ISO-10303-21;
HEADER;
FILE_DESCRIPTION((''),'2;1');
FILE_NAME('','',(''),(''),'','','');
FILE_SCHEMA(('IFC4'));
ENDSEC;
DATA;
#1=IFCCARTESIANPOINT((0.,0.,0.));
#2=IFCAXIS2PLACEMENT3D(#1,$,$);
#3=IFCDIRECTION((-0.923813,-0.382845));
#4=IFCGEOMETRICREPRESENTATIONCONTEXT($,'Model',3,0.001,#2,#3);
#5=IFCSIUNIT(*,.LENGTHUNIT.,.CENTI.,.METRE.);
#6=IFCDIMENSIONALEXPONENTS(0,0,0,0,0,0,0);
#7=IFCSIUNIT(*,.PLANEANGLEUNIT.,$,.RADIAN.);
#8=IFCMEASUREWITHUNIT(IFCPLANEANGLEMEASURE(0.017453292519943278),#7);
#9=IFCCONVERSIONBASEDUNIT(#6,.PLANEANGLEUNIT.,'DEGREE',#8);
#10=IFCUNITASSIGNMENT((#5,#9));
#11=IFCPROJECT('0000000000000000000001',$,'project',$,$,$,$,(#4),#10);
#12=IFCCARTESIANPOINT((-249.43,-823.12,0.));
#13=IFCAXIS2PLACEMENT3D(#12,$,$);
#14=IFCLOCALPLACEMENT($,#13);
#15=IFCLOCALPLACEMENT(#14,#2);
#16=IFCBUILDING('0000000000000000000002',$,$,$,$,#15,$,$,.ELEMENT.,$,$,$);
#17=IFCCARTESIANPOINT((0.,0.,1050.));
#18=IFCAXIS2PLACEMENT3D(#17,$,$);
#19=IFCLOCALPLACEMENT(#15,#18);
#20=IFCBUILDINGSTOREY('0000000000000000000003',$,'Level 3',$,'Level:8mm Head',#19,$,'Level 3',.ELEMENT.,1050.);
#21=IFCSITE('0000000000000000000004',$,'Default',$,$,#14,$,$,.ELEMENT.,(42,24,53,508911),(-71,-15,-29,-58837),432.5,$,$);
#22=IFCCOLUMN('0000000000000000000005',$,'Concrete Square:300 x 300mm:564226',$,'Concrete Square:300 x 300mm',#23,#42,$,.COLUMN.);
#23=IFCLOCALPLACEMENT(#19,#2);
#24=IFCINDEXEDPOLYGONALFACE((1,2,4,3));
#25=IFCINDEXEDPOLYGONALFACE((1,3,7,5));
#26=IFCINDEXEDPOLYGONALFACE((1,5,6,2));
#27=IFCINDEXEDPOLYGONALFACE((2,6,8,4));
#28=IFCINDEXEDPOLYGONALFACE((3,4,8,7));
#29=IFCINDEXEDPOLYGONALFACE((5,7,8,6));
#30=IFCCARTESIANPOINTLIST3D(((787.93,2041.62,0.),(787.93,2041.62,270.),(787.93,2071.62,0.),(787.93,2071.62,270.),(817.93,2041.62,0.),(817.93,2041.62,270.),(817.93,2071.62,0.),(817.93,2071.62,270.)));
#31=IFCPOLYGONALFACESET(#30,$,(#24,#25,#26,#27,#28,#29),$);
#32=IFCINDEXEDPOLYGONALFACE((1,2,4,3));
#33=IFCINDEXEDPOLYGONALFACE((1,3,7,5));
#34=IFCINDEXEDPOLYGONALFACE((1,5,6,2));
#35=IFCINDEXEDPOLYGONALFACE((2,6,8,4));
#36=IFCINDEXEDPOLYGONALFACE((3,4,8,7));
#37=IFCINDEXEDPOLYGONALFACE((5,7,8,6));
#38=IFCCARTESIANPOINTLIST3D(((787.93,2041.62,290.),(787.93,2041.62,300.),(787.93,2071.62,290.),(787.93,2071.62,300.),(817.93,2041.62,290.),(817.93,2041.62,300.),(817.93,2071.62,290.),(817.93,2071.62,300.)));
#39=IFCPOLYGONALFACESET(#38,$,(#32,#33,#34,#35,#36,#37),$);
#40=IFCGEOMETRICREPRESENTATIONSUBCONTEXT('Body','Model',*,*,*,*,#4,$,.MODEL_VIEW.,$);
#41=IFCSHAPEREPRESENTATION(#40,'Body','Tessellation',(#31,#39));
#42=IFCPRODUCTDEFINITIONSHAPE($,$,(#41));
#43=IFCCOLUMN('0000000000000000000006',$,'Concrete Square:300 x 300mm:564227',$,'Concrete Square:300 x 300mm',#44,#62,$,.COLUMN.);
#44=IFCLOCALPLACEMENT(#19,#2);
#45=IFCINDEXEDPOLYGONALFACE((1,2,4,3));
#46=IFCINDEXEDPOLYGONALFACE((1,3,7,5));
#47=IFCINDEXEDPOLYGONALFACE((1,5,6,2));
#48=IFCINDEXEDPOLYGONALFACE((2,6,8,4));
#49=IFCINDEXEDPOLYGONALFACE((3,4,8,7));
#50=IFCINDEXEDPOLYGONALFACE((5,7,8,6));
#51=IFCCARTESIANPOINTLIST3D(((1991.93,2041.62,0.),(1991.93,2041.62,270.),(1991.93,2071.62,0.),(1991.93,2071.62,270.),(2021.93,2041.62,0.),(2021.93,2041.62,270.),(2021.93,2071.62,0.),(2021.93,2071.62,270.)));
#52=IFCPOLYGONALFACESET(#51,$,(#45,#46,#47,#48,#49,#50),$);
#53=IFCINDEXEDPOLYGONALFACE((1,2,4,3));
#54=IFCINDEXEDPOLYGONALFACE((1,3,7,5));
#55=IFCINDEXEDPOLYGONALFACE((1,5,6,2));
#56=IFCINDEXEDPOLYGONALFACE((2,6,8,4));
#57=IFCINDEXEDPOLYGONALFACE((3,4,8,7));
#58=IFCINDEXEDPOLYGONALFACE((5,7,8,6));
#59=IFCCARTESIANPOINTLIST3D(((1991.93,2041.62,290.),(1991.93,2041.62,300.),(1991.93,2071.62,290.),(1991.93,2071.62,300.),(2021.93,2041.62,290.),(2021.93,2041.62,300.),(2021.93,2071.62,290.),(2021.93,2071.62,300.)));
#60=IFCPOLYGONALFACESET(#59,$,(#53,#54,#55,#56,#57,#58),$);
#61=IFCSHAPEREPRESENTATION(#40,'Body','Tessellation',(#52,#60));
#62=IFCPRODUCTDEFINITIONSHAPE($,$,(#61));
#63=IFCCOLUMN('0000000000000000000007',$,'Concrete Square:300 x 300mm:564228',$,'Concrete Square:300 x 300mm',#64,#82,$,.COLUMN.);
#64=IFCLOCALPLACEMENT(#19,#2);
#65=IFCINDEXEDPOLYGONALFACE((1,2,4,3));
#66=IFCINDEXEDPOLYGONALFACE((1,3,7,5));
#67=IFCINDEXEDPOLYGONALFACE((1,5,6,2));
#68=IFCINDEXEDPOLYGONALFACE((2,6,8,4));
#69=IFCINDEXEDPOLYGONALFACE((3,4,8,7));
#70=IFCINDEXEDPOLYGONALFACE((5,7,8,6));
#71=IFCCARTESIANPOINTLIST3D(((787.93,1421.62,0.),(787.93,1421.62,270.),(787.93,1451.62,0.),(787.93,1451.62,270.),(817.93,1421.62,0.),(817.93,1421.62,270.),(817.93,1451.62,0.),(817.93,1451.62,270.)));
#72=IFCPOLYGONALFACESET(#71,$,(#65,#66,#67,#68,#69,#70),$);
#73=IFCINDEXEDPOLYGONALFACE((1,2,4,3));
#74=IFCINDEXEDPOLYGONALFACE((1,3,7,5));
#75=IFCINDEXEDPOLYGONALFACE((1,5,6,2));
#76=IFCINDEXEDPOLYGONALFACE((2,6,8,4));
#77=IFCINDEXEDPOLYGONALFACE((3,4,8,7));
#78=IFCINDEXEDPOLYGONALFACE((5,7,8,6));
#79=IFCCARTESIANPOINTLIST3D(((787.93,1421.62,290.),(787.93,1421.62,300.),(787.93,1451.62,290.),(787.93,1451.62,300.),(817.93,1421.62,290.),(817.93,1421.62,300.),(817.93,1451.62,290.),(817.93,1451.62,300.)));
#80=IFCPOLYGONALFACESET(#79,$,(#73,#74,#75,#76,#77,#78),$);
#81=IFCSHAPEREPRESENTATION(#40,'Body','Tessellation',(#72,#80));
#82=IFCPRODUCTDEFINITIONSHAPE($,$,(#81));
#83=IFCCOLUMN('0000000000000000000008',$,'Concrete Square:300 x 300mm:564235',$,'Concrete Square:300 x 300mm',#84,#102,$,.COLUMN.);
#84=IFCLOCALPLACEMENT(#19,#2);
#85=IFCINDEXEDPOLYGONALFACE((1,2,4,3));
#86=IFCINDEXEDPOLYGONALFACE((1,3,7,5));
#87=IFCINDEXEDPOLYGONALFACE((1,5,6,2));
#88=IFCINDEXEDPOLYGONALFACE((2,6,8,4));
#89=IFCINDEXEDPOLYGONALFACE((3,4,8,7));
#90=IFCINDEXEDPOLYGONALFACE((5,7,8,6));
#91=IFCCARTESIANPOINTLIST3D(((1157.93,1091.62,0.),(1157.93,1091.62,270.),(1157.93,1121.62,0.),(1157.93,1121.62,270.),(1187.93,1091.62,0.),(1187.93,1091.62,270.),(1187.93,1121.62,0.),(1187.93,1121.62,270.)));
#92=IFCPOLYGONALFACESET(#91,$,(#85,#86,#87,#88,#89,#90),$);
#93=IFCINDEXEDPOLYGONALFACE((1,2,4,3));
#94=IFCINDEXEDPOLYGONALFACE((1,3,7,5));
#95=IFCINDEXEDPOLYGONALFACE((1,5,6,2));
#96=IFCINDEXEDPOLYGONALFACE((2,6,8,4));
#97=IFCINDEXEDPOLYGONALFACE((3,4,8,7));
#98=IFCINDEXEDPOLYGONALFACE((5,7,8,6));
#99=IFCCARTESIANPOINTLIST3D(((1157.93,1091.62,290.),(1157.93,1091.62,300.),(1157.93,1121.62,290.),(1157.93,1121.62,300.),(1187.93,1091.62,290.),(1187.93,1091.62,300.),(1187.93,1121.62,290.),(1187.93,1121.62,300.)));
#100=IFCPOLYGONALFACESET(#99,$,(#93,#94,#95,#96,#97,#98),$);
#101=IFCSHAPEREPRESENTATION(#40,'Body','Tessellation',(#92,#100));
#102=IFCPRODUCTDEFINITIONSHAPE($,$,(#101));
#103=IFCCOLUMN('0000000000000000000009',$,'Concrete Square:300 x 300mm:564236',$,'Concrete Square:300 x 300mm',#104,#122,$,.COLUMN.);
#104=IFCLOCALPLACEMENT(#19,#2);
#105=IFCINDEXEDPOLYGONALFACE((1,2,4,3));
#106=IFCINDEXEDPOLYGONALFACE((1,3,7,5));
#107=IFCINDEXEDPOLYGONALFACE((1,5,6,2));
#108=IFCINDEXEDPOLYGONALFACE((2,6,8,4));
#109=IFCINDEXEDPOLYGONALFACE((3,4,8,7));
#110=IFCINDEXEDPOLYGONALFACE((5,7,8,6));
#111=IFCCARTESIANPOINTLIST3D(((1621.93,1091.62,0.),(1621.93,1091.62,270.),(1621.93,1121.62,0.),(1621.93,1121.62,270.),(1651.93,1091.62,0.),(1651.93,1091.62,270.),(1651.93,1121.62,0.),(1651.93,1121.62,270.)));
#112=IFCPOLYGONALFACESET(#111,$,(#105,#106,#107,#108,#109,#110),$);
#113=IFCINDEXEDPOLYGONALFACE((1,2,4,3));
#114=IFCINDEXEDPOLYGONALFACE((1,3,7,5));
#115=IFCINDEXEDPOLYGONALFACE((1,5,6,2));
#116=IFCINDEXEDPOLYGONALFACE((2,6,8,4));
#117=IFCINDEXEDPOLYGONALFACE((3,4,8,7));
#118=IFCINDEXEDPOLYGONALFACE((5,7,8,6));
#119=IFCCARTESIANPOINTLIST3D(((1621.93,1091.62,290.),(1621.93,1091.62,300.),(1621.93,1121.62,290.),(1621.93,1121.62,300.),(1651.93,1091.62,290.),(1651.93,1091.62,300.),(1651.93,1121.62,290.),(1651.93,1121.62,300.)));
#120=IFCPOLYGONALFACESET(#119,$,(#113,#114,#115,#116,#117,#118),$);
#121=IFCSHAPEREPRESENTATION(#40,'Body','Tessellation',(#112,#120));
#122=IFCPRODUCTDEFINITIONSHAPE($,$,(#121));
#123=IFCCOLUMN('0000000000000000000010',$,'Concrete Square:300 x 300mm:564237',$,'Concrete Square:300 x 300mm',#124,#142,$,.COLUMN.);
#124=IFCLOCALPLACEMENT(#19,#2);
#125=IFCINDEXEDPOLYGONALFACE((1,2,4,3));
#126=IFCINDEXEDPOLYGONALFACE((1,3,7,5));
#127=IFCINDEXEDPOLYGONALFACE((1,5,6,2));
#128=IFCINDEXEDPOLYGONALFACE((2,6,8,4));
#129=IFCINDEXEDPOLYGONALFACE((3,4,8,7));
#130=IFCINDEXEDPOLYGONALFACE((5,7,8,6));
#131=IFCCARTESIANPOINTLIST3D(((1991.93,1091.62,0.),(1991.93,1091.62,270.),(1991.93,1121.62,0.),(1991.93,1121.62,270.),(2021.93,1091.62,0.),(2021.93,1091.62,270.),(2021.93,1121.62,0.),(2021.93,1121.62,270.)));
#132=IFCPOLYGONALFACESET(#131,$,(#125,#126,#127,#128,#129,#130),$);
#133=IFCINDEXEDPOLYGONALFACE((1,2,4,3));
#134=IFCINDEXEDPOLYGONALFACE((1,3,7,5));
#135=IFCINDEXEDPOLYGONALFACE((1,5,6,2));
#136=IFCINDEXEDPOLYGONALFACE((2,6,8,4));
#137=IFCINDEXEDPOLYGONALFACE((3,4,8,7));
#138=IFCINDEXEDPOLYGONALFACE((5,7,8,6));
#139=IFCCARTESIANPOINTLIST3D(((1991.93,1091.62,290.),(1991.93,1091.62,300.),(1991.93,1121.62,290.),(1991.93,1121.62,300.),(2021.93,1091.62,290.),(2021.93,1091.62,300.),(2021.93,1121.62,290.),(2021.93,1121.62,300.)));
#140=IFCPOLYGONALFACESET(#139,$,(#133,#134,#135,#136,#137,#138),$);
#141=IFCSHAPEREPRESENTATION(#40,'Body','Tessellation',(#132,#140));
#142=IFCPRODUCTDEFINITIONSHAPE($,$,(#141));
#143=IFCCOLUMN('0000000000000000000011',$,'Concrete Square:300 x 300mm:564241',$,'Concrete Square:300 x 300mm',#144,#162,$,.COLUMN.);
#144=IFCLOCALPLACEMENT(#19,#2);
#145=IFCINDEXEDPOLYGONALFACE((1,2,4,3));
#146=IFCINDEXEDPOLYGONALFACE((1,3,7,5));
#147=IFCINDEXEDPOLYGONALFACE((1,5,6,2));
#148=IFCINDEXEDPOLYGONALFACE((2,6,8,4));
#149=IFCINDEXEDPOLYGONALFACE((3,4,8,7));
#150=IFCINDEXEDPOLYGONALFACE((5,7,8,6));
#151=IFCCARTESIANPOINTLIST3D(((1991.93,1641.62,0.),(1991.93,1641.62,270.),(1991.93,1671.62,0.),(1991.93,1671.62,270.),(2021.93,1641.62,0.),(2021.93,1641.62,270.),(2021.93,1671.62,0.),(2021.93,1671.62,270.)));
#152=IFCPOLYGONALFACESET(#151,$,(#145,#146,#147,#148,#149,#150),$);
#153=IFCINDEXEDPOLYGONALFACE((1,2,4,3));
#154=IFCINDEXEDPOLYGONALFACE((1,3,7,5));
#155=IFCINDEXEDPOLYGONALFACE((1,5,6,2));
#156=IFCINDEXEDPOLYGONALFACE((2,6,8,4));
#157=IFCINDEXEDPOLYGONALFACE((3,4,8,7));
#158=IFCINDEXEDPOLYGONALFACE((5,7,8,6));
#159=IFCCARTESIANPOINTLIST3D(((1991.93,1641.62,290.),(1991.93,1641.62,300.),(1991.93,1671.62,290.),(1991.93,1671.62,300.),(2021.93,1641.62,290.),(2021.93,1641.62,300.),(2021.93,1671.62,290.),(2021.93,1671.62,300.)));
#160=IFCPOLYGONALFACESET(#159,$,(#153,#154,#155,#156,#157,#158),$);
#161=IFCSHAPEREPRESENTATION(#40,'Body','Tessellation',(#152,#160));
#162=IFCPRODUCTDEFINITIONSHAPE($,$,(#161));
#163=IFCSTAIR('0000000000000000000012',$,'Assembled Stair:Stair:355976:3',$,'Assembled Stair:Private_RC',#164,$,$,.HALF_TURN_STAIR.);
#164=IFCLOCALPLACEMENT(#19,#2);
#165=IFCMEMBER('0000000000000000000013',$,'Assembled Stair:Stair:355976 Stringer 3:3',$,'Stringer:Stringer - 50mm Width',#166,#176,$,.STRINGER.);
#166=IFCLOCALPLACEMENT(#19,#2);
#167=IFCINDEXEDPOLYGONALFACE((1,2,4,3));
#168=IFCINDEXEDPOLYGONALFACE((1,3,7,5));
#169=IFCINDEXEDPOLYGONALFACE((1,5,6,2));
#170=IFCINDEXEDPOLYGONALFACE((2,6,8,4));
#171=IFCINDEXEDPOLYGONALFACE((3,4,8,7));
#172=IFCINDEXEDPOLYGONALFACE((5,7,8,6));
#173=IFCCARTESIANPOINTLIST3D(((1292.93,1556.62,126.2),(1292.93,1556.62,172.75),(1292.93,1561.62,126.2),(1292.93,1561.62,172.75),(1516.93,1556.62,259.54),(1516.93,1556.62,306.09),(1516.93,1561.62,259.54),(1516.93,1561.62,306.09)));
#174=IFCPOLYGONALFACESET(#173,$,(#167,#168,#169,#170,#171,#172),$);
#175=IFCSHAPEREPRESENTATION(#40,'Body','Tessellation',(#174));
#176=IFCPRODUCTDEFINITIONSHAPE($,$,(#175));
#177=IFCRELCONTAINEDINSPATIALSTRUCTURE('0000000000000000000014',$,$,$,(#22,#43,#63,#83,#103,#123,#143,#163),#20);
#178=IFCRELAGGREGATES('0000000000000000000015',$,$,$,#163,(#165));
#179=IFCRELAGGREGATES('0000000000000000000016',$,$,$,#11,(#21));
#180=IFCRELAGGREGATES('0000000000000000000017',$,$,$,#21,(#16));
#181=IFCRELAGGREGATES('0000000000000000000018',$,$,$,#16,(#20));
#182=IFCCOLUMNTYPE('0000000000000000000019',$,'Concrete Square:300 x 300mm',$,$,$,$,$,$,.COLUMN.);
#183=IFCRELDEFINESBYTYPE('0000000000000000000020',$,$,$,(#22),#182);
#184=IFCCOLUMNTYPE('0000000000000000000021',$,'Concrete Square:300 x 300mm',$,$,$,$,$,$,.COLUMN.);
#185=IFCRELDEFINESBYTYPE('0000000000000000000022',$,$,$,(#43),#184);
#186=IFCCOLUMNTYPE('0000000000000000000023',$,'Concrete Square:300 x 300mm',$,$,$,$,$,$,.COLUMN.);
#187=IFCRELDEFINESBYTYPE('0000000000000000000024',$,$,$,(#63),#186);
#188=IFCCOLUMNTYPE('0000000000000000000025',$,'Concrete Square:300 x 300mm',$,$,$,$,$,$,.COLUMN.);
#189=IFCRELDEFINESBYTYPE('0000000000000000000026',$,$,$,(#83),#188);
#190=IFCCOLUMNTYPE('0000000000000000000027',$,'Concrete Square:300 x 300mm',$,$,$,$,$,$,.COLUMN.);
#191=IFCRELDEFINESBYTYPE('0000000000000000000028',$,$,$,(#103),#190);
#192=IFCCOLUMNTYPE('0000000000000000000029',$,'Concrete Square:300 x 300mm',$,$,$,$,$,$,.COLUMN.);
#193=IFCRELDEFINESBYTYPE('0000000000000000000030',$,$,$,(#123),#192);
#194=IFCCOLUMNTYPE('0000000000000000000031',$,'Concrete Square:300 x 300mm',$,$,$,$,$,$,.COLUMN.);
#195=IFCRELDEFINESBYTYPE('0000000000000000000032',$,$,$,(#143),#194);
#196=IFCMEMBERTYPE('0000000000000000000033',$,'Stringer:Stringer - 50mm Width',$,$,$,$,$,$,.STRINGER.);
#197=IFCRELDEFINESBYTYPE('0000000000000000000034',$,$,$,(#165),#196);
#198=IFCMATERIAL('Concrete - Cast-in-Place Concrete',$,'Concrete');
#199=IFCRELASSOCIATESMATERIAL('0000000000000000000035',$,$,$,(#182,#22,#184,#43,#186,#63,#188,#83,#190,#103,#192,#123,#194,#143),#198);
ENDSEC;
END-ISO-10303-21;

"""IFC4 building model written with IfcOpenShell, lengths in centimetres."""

from ifc_helpers import new_model, entity, si_unit, converted_unit, direction, frame, origin, place, context, subcontext, project, spatial, indexed_curve, outline, extrude, source, transform, mapped, material, type_object, type_shapes, element, aggregate, save


model = new_model("IFC4")

# Units and contexts
model_context = context("Model", 3, precision=0.001, world=origin(), true_north=direction((-0.923813, -0.382845)))
body_context = subcontext(model_context, "Body", "Model", "MODEL_VIEW")
ifc_project = project(units=[si_unit("LENGTHUNIT", "METRE", prefix="CENTI"), converted_unit("PLANEANGLEUNIT", "DEGREE", entity("IfcPlaneAngleMeasure", 0.017453292519943278), si_unit("PLANEANGLEUNIT", "RADIAN"), dimensions=[0, 0, 0, 0, 0, 0, 0])], contexts=[model_context])

# Site, building, storey
site_placement = place(None, frame((-249.43, -823.12, 0.0)))
site = spatial("IfcSite", under=ifc_project, at=site_placement, Name="Default", CompositionType="ELEMENT", RefLatitude=(42, 24, 53, 508911), RefLongitude=(-71, -15, -29, -58837), RefElevation=432.5)
building_placement = place(site_placement, origin())
building = spatial("IfcBuilding", under=site, at=building_placement, CompositionType="ELEMENT")
storey_placement = place(building_placement, frame((0.0, 0.0, 1050.0)))
storey = spatial("IfcBuildingStorey", under=building, at=storey_placement, Name="Level 3", ObjectType="Level:8mm Head", LongName="Level 3", CompositionType="ELEMENT", Elevation=1050.0)

# Columns
ifc_material_1 = material(Name="Concrete - Cast-in-Place Concrete", Category="Concrete")
column_type_1 = type_object("IfcColumnType", Name="Concrete Square:300 x 300mm", PredefinedType="COLUMN", material=ifc_material_1)
shared_shape_1 = source(origin(), body_context, "Body", "SweptSolid", [
    extrude(outline(indexed_curve([(-15.0, -15.0), (15.0, -15.0), (15.0, 15.0), (-15.0, 15.0), (-15.0, -15.0)], self_intersect=False)), frame((802.93, 2056.62, 1050.0), z_axis=(0.0, 0.0, 1.0), x_axis=(-1.0, 0.0, 0.0)), (0.0, 0.0, 1.0), 270.0),
    extrude(outline(indexed_curve([(-15.0, -15.0), (15.0, -15.0), (15.0, 15.0), (-15.0, 15.0), (-15.0, -15.0)], self_intersect=False)), frame((802.93, 2056.62, 1340.0), z_axis=(0.0, 0.0, 1.0), x_axis=(-1.0, 0.0, 0.0)), (0.0, 0.0, 1.0), 10.0),
])
type_shapes(column_type_1, [shared_shape_1])
column_1_placement = place(storey_placement, frame((0.0, 0.0, -1050.0)))
element("IfcColumn", 1, at=column_1_placement, inside=storey, type_object=column_type_1, material=ifc_material_1, Name="Concrete Square:300 x 300mm:564226", ObjectType="Concrete Square:300 x 300mm", PredefinedType="COLUMN", context=body_context, shape_type="MappedRepresentation", body=[
    mapped(shared_shape_1, transform((0.0, 0.0, 0.0), scale=1.0)),
])
column_type_2 = type_object("IfcColumnType", Name="Concrete Square:300 x 300mm", PredefinedType="COLUMN", material=ifc_material_1)
shared_shape_2 = source(origin(), body_context, "Body", "SweptSolid", [
    extrude(outline(indexed_curve([(-15.0, -15.0), (15.0, -15.0), (15.0, 15.0), (-15.0, 15.0), (-15.0, -15.0)], self_intersect=False)), frame((2006.93, 2056.62, 1050.0), z_axis=(0.0, 0.0, 1.0), x_axis=(-1.0, 0.0, 0.0)), (0.0, 0.0, 1.0), 270.0),
    extrude(outline(indexed_curve([(-15.0, -15.0), (15.0, -15.0), (15.0, 15.0), (-15.0, 15.0), (-15.0, -15.0)], self_intersect=False)), frame((2006.93, 2056.62, 1340.0), z_axis=(0.0, 0.0, 1.0), x_axis=(-1.0, 0.0, 0.0)), (0.0, 0.0, 1.0), 10.0),
])
type_shapes(column_type_2, [shared_shape_2])
column_2_placement = place(storey_placement, frame((0.0, 0.0, -1050.0)))
element("IfcColumn", 2, at=column_2_placement, inside=storey, type_object=column_type_2, material=ifc_material_1, Name="Concrete Square:300 x 300mm:564227", ObjectType="Concrete Square:300 x 300mm", PredefinedType="COLUMN", context=body_context, shape_type="MappedRepresentation", body=[
    mapped(shared_shape_2, transform((0.0, 0.0, 0.0), scale=1.0)),
])
column_type_3 = type_object("IfcColumnType", Name="Concrete Square:300 x 300mm", PredefinedType="COLUMN", material=ifc_material_1)
shared_shape_3 = source(origin(), body_context, "Body", "SweptSolid", [
    extrude(outline(indexed_curve([(-15.0, -15.0), (15.0, -15.0), (15.0, 15.0), (-15.0, 15.0), (-15.0, -15.0)], self_intersect=False)), frame((802.93, 1436.62, 1050.0), z_axis=(0.0, 0.0, 1.0), x_axis=(-1.0, 0.0, 0.0)), (0.0, 0.0, 1.0), 270.0),
    extrude(outline(indexed_curve([(-15.0, -15.0), (15.0, -15.0), (15.0, 15.0), (-15.0, 15.0), (-15.0, -15.0)], self_intersect=False)), frame((802.93, 1436.62, 1340.0), z_axis=(0.0, 0.0, 1.0), x_axis=(-1.0, 0.0, 0.0)), (0.0, 0.0, 1.0), 10.0),
])
type_shapes(column_type_3, [shared_shape_3])
column_3_placement = place(storey_placement, frame((0.0, 0.0, -1050.0)))
element("IfcColumn", 3, at=column_3_placement, inside=storey, type_object=column_type_3, material=ifc_material_1, Name="Concrete Square:300 x 300mm:564228", ObjectType="Concrete Square:300 x 300mm", PredefinedType="COLUMN", context=body_context, shape_type="MappedRepresentation", body=[
    mapped(shared_shape_3, transform((0.0, 0.0, 0.0), scale=1.0)),
])
column_type_4 = type_object("IfcColumnType", Name="Concrete Square:300 x 300mm", PredefinedType="COLUMN", material=ifc_material_1)
shared_shape_4 = source(origin(), body_context, "Body", "SweptSolid", [
    extrude(outline(indexed_curve([(-15.0, -15.0), (15.0, -15.0), (15.0, 15.0), (-15.0, 15.0), (-15.0, -15.0)], self_intersect=False)), frame((1172.93, 1106.62, 1050.0), z_axis=(0.0, 0.0, 1.0), x_axis=(-1.0, 0.0, 0.0)), (0.0, 0.0, 1.0), 270.0),
    extrude(outline(indexed_curve([(-15.0, -15.0), (15.0, -15.0), (15.0, 15.0), (-15.0, 15.0), (-15.0, -15.0)], self_intersect=False)), frame((1172.93, 1106.62, 1340.0), z_axis=(0.0, 0.0, 1.0), x_axis=(-1.0, 0.0, 0.0)), (0.0, 0.0, 1.0), 10.0),
])
type_shapes(column_type_4, [shared_shape_4])
column_4_placement = place(storey_placement, frame((0.0, 0.0, -1050.0)))
element("IfcColumn", 4, at=column_4_placement, inside=storey, type_object=column_type_4, material=ifc_material_1, Name="Concrete Square:300 x 300mm:564235", ObjectType="Concrete Square:300 x 300mm", PredefinedType="COLUMN", context=body_context, shape_type="MappedRepresentation", body=[
    mapped(shared_shape_4, transform((0.0, 0.0, 0.0), scale=1.0)),
])
column_type_5 = type_object("IfcColumnType", Name="Concrete Square:300 x 300mm", PredefinedType="COLUMN", material=ifc_material_1)
shared_shape_5 = source(origin(), body_context, "Body", "SweptSolid", [
    extrude(outline(indexed_curve([(-15.0, -15.0), (15.0, -15.0), (15.0, 15.0), (-15.0, 15.0), (-15.0, -15.0)], self_intersect=False)), frame((1636.93, 1106.62, 1050.0), z_axis=(0.0, 0.0, 1.0), x_axis=(-1.0, 0.0, 0.0)), (0.0, 0.0, 1.0), 270.0),
    extrude(outline(indexed_curve([(-15.0, -15.0), (15.0, -15.0), (15.0, 15.0), (-15.0, 15.0), (-15.0, -15.0)], self_intersect=False)), frame((1636.93, 1106.62, 1340.0), z_axis=(0.0, 0.0, 1.0), x_axis=(-1.0, 0.0, 0.0)), (0.0, 0.0, 1.0), 10.0),
])
type_shapes(column_type_5, [shared_shape_5])
column_5_placement = place(storey_placement, frame((0.0, 0.0, -1050.0)))
element("IfcColumn", 5, at=column_5_placement, inside=storey, type_object=column_type_5, material=ifc_material_1, Name="Concrete Square:300 x 300mm:564236", ObjectType="Concrete Square:300 x 300mm", PredefinedType="COLUMN", context=body_context, shape_type="MappedRepresentation", body=[
    mapped(shared_shape_5, transform((0.0, 0.0, 0.0), scale=1.0)),
])
column_type_6 = type_object("IfcColumnType", Name="Concrete Square:300 x 300mm", PredefinedType="COLUMN", material=ifc_material_1)
shared_shape_6 = source(origin(), body_context, "Body", "SweptSolid", [
    extrude(outline(indexed_curve([(-15.0, -15.0), (15.0, -15.0), (15.0, 15.0), (-15.0, 15.0), (-15.0, -15.0)], self_intersect=False)), frame((2006.93, 1106.62, 1050.0), z_axis=(0.0, 0.0, 1.0), x_axis=(-1.0, 0.0, 0.0)), (0.0, 0.0, 1.0), 270.0),
    extrude(outline(indexed_curve([(-15.0, -15.0), (15.0, -15.0), (15.0, 15.0), (-15.0, 15.0), (-15.0, -15.0)], self_intersect=False)), frame((2006.93, 1106.62, 1340.0), z_axis=(0.0, 0.0, 1.0), x_axis=(-1.0, 0.0, 0.0)), (0.0, 0.0, 1.0), 10.0),
])
type_shapes(column_type_6, [shared_shape_6])
column_6_placement = place(storey_placement, frame((0.0, 0.0, -1050.0)))
element("IfcColumn", 6, at=column_6_placement, inside=storey, type_object=column_type_6, material=ifc_material_1, Name="Concrete Square:300 x 300mm:564237", ObjectType="Concrete Square:300 x 300mm", PredefinedType="COLUMN", context=body_context, shape_type="MappedRepresentation", body=[
    mapped(shared_shape_6, transform((0.0, 0.0, 0.0), scale=1.0)),
])
column_type_7 = type_object("IfcColumnType", Name="Concrete Square:300 x 300mm", PredefinedType="COLUMN", material=ifc_material_1)
shared_shape_7 = source(origin(), body_context, "Body", "SweptSolid", [
    extrude(outline(indexed_curve([(-15.0, -15.0), (15.0, -15.0), (15.0, 15.0), (-15.0, 15.0), (-15.0, -15.0)], self_intersect=False)), frame((2006.93, 1656.62, 1050.0), z_axis=(0.0, 0.0, 1.0), x_axis=(-1.0, 0.0, 0.0)), (0.0, 0.0, 1.0), 270.0),
    extrude(outline(indexed_curve([(-15.0, -15.0), (15.0, -15.0), (15.0, 15.0), (-15.0, 15.0), (-15.0, -15.0)], self_intersect=False)), frame((2006.93, 1656.62, 1340.0), z_axis=(0.0, 0.0, 1.0), x_axis=(-1.0, 0.0, 0.0)), (0.0, 0.0, 1.0), 10.0),
])
type_shapes(column_type_7, [shared_shape_7])
column_7_placement = place(storey_placement, frame((0.0, 0.0, -1050.0)))
element("IfcColumn", 7, at=column_7_placement, inside=storey, type_object=column_type_7, material=ifc_material_1, Name="Concrete Square:300 x 300mm:564241", ObjectType="Concrete Square:300 x 300mm", PredefinedType="COLUMN", context=body_context, shape_type="MappedRepresentation", body=[
    mapped(shared_shape_7, transform((0.0, 0.0, 0.0), scale=1.0)),
])

# Stair, member
stair_placement = place(storey_placement, origin())
stair = element("IfcStair", 8, at=stair_placement, inside=storey, Name="Assembled Stair:Stair:355976:3", ObjectType="Assembled Stair:Private_RC", PredefinedType="HALF_TURN_STAIR")
member_type = type_object("IfcMemberType", Name="Stringer:Stringer - 50mm Width", PredefinedType="STRINGER")
member_1_placement = place(stair_placement, origin())
member_1 = element("IfcMember", 9, at=member_1_placement, type_object=member_type, Name="Assembled Stair:Stair:355976 Stringer 3:3", ObjectType="Stringer:Stringer - 50mm Width", PredefinedType="STRINGER", context=body_context, shape_type="SweptSolid", body=[
    extrude(outline(indexed_curve([(-118.43, -20.0), (142.24, -20.0), (118.43, 20.0), (-142.24, 20.0), (-118.43, -20.0)], self_intersect=False)), frame((1404.93, 1556.62, 216.15), z_axis=(0.0, 1.0, 0.0), x_axis=(0.859293, 0.0, 0.511484)), (0.0, 0.0, 1.0), 5.0),
])

aggregate(stair, [member_1])

save(model, "model.ifc")
